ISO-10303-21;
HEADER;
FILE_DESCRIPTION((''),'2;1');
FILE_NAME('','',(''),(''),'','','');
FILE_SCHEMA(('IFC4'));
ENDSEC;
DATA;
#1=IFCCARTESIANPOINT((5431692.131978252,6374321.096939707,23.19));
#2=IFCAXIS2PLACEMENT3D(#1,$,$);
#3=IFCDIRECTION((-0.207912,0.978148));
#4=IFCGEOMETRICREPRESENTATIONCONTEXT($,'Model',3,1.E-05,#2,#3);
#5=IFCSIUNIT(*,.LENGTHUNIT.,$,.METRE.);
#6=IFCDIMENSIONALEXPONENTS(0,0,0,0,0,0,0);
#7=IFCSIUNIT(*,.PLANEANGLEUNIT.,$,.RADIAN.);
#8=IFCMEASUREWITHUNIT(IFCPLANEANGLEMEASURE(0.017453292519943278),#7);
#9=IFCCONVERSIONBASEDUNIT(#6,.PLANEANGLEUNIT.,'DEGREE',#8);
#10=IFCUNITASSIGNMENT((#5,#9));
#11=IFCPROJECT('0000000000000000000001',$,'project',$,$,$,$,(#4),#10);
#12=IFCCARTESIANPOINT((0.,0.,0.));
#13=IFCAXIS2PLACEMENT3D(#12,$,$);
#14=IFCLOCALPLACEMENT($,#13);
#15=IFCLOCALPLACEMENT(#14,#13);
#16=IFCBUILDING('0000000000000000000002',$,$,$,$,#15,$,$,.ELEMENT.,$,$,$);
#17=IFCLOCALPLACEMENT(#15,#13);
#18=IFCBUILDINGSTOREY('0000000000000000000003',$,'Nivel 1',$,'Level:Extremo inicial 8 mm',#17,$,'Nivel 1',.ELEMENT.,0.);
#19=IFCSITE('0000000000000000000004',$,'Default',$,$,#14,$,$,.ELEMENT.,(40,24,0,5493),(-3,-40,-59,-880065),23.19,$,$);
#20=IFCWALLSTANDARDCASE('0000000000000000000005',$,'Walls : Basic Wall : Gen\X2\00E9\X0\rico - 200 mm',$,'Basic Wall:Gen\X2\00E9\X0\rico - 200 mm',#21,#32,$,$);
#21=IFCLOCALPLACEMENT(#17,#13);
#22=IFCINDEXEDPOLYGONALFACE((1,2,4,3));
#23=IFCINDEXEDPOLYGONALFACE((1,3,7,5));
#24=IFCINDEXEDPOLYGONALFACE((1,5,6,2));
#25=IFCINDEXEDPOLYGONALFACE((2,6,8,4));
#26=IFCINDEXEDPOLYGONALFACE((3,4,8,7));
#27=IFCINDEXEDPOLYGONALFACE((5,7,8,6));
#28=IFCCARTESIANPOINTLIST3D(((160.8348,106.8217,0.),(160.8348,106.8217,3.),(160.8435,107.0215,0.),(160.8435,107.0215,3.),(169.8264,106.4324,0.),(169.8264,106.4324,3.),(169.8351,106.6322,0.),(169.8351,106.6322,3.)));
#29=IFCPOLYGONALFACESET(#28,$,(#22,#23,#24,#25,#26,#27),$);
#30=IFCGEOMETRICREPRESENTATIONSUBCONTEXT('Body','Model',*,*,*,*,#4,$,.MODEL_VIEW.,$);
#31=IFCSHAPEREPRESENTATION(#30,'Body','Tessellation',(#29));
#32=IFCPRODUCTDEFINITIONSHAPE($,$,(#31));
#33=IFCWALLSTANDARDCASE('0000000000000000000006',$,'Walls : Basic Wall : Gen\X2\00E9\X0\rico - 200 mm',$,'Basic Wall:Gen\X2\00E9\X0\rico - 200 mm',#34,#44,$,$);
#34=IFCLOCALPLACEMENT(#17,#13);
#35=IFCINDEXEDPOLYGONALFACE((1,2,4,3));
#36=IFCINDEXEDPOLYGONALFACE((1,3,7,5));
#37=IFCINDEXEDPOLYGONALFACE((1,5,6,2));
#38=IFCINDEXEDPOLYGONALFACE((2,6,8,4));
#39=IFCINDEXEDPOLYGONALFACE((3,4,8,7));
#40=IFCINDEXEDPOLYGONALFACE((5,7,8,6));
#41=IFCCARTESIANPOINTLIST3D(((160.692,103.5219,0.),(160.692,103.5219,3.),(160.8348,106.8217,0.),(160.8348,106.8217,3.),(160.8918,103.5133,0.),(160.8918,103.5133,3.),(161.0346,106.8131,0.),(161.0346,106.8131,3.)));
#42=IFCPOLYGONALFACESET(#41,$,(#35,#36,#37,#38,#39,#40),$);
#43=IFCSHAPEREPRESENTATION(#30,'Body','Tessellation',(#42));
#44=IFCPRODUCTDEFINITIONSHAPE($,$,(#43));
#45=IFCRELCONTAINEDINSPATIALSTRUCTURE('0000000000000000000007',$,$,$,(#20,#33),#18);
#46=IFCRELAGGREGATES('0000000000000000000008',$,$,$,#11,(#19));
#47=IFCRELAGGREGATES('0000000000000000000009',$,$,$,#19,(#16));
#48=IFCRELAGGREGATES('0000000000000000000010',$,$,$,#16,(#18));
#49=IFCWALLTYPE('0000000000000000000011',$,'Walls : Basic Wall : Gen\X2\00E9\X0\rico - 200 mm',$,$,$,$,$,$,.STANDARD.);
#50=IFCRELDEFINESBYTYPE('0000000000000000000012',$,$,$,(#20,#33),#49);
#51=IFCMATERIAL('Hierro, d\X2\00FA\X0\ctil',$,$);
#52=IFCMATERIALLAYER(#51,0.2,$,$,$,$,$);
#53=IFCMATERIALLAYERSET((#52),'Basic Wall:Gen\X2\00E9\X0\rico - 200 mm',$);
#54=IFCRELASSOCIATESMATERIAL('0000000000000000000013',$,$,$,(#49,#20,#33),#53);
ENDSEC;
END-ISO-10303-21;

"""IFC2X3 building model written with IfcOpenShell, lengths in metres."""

from ifc_helpers import new_model, entity, si_unit, converted_unit, direction, frame, frame_2d, origin, place, context, subcontext, project, spatial, rectangle, extrude, material, layer, layer_set, layer_usage, type_object, element, save


model = new_model("IFC2X3")

# Units and contexts
model_context = context("Model", 3, precision=1e-05, world=frame((5431692.131978252, 6374321.096939707, 23.19)), true_north=direction((-0.207912, 0.978148)))
body_context = subcontext(model_context, "Body", "Model", "MODEL_VIEW")
ifc_project = project(units=[si_unit("LENGTHUNIT", "METRE"), converted_unit("PLANEANGLEUNIT", "DEGREE", entity("IfcPlaneAngleMeasure", 0.017453292519943278), si_unit("PLANEANGLEUNIT", "RADIAN"), dimensions=[0, 0, 0, 0, 0, 0, 0])], contexts=[model_context])

# Site, building, storey
site_placement = place(None, origin())
site = spatial("IfcSite", under=ifc_project, at=site_placement, Name="Default", CompositionType="ELEMENT", RefLatitude=(40, 24, 0, 5493), RefLongitude=(-3, -40, -59, -880065), RefElevation=23.19)
building_placement = place(site_placement, origin())
building = spatial("IfcBuilding", under=site, at=building_placement, CompositionType="ELEMENT")
storey_placement = place(building_placement, origin())
storey = spatial("IfcBuildingStorey", under=building, at=storey_placement, Name="Nivel 1", ObjectType="Level:Extremo inicial 8 mm", LongName="Nivel 1", CompositionType="ELEMENT", Elevation=0.0)

# Walls
ifc_material_1 = material(Name="Hierro, dúctil")
ifc_layer = layer(ifc_material_1, 0.2)
ifc_layer_set = layer_set([ifc_layer], Name="Basic Wall:Genérico - 200 mm")
wall_type = type_object("IfcWallType", Name="Walls : Basic Wall : Genérico - 200 mm", PredefinedType="STANDARD", material=ifc_layer_set)
ifc_layer_usage_1 = layer_usage(ifc_layer_set, "AXIS2", "NEGATIVE", 0.1)
wall_1_placement = place(storey_placement, frame((160.8392, 106.9216, 0.0), z_axis=(0.0, 0.0, 1.0), x_axis=(0.999064, -0.043255, 0.0)))
element("IfcWallStandardCase", 1, at=wall_1_placement, inside=storey, type_object=wall_type, material=ifc_layer_usage_1, Name="Walls : Basic Wall : Genérico - 200 mm", ObjectType="Basic Wall:Genérico - 200 mm", context=body_context, shape_type="SweptSolid", body=[
    extrude(rectangle(XDim=9.0, YDim=0.2, at=frame_2d((4.5, 0.0), x_axis=(-1.0, 0.0))), origin(), (0.0, 0.0, 1.0), 3.0),
])
ifc_layer_usage_2 = layer_usage(ifc_layer_set, "AXIS2", "NEGATIVE", 0.1)
wall_2_placement = place(storey_placement, frame((160.7919, 103.5176, 0.0), z_axis=(0.0, 0.0, 1.0), x_axis=(0.043255, 0.999064, 0.0)))
element("IfcWallStandardCase", 2, at=wall_2_placement, inside=storey, type_object=wall_type, material=ifc_layer_usage_2, Name="Walls : Basic Wall : Genérico - 200 mm", ObjectType="Basic Wall:Genérico - 200 mm", context=body_context, shape_type="SweptSolid", body=[
    extrude(rectangle(XDim=3.3029, YDim=0.2, at=frame_2d((1.6514, 0.0), x_axis=(-1.0, 0.0))), origin(), (0.0, 0.0, 1.0), 3.0),
])

save(model, "model.ifc")
